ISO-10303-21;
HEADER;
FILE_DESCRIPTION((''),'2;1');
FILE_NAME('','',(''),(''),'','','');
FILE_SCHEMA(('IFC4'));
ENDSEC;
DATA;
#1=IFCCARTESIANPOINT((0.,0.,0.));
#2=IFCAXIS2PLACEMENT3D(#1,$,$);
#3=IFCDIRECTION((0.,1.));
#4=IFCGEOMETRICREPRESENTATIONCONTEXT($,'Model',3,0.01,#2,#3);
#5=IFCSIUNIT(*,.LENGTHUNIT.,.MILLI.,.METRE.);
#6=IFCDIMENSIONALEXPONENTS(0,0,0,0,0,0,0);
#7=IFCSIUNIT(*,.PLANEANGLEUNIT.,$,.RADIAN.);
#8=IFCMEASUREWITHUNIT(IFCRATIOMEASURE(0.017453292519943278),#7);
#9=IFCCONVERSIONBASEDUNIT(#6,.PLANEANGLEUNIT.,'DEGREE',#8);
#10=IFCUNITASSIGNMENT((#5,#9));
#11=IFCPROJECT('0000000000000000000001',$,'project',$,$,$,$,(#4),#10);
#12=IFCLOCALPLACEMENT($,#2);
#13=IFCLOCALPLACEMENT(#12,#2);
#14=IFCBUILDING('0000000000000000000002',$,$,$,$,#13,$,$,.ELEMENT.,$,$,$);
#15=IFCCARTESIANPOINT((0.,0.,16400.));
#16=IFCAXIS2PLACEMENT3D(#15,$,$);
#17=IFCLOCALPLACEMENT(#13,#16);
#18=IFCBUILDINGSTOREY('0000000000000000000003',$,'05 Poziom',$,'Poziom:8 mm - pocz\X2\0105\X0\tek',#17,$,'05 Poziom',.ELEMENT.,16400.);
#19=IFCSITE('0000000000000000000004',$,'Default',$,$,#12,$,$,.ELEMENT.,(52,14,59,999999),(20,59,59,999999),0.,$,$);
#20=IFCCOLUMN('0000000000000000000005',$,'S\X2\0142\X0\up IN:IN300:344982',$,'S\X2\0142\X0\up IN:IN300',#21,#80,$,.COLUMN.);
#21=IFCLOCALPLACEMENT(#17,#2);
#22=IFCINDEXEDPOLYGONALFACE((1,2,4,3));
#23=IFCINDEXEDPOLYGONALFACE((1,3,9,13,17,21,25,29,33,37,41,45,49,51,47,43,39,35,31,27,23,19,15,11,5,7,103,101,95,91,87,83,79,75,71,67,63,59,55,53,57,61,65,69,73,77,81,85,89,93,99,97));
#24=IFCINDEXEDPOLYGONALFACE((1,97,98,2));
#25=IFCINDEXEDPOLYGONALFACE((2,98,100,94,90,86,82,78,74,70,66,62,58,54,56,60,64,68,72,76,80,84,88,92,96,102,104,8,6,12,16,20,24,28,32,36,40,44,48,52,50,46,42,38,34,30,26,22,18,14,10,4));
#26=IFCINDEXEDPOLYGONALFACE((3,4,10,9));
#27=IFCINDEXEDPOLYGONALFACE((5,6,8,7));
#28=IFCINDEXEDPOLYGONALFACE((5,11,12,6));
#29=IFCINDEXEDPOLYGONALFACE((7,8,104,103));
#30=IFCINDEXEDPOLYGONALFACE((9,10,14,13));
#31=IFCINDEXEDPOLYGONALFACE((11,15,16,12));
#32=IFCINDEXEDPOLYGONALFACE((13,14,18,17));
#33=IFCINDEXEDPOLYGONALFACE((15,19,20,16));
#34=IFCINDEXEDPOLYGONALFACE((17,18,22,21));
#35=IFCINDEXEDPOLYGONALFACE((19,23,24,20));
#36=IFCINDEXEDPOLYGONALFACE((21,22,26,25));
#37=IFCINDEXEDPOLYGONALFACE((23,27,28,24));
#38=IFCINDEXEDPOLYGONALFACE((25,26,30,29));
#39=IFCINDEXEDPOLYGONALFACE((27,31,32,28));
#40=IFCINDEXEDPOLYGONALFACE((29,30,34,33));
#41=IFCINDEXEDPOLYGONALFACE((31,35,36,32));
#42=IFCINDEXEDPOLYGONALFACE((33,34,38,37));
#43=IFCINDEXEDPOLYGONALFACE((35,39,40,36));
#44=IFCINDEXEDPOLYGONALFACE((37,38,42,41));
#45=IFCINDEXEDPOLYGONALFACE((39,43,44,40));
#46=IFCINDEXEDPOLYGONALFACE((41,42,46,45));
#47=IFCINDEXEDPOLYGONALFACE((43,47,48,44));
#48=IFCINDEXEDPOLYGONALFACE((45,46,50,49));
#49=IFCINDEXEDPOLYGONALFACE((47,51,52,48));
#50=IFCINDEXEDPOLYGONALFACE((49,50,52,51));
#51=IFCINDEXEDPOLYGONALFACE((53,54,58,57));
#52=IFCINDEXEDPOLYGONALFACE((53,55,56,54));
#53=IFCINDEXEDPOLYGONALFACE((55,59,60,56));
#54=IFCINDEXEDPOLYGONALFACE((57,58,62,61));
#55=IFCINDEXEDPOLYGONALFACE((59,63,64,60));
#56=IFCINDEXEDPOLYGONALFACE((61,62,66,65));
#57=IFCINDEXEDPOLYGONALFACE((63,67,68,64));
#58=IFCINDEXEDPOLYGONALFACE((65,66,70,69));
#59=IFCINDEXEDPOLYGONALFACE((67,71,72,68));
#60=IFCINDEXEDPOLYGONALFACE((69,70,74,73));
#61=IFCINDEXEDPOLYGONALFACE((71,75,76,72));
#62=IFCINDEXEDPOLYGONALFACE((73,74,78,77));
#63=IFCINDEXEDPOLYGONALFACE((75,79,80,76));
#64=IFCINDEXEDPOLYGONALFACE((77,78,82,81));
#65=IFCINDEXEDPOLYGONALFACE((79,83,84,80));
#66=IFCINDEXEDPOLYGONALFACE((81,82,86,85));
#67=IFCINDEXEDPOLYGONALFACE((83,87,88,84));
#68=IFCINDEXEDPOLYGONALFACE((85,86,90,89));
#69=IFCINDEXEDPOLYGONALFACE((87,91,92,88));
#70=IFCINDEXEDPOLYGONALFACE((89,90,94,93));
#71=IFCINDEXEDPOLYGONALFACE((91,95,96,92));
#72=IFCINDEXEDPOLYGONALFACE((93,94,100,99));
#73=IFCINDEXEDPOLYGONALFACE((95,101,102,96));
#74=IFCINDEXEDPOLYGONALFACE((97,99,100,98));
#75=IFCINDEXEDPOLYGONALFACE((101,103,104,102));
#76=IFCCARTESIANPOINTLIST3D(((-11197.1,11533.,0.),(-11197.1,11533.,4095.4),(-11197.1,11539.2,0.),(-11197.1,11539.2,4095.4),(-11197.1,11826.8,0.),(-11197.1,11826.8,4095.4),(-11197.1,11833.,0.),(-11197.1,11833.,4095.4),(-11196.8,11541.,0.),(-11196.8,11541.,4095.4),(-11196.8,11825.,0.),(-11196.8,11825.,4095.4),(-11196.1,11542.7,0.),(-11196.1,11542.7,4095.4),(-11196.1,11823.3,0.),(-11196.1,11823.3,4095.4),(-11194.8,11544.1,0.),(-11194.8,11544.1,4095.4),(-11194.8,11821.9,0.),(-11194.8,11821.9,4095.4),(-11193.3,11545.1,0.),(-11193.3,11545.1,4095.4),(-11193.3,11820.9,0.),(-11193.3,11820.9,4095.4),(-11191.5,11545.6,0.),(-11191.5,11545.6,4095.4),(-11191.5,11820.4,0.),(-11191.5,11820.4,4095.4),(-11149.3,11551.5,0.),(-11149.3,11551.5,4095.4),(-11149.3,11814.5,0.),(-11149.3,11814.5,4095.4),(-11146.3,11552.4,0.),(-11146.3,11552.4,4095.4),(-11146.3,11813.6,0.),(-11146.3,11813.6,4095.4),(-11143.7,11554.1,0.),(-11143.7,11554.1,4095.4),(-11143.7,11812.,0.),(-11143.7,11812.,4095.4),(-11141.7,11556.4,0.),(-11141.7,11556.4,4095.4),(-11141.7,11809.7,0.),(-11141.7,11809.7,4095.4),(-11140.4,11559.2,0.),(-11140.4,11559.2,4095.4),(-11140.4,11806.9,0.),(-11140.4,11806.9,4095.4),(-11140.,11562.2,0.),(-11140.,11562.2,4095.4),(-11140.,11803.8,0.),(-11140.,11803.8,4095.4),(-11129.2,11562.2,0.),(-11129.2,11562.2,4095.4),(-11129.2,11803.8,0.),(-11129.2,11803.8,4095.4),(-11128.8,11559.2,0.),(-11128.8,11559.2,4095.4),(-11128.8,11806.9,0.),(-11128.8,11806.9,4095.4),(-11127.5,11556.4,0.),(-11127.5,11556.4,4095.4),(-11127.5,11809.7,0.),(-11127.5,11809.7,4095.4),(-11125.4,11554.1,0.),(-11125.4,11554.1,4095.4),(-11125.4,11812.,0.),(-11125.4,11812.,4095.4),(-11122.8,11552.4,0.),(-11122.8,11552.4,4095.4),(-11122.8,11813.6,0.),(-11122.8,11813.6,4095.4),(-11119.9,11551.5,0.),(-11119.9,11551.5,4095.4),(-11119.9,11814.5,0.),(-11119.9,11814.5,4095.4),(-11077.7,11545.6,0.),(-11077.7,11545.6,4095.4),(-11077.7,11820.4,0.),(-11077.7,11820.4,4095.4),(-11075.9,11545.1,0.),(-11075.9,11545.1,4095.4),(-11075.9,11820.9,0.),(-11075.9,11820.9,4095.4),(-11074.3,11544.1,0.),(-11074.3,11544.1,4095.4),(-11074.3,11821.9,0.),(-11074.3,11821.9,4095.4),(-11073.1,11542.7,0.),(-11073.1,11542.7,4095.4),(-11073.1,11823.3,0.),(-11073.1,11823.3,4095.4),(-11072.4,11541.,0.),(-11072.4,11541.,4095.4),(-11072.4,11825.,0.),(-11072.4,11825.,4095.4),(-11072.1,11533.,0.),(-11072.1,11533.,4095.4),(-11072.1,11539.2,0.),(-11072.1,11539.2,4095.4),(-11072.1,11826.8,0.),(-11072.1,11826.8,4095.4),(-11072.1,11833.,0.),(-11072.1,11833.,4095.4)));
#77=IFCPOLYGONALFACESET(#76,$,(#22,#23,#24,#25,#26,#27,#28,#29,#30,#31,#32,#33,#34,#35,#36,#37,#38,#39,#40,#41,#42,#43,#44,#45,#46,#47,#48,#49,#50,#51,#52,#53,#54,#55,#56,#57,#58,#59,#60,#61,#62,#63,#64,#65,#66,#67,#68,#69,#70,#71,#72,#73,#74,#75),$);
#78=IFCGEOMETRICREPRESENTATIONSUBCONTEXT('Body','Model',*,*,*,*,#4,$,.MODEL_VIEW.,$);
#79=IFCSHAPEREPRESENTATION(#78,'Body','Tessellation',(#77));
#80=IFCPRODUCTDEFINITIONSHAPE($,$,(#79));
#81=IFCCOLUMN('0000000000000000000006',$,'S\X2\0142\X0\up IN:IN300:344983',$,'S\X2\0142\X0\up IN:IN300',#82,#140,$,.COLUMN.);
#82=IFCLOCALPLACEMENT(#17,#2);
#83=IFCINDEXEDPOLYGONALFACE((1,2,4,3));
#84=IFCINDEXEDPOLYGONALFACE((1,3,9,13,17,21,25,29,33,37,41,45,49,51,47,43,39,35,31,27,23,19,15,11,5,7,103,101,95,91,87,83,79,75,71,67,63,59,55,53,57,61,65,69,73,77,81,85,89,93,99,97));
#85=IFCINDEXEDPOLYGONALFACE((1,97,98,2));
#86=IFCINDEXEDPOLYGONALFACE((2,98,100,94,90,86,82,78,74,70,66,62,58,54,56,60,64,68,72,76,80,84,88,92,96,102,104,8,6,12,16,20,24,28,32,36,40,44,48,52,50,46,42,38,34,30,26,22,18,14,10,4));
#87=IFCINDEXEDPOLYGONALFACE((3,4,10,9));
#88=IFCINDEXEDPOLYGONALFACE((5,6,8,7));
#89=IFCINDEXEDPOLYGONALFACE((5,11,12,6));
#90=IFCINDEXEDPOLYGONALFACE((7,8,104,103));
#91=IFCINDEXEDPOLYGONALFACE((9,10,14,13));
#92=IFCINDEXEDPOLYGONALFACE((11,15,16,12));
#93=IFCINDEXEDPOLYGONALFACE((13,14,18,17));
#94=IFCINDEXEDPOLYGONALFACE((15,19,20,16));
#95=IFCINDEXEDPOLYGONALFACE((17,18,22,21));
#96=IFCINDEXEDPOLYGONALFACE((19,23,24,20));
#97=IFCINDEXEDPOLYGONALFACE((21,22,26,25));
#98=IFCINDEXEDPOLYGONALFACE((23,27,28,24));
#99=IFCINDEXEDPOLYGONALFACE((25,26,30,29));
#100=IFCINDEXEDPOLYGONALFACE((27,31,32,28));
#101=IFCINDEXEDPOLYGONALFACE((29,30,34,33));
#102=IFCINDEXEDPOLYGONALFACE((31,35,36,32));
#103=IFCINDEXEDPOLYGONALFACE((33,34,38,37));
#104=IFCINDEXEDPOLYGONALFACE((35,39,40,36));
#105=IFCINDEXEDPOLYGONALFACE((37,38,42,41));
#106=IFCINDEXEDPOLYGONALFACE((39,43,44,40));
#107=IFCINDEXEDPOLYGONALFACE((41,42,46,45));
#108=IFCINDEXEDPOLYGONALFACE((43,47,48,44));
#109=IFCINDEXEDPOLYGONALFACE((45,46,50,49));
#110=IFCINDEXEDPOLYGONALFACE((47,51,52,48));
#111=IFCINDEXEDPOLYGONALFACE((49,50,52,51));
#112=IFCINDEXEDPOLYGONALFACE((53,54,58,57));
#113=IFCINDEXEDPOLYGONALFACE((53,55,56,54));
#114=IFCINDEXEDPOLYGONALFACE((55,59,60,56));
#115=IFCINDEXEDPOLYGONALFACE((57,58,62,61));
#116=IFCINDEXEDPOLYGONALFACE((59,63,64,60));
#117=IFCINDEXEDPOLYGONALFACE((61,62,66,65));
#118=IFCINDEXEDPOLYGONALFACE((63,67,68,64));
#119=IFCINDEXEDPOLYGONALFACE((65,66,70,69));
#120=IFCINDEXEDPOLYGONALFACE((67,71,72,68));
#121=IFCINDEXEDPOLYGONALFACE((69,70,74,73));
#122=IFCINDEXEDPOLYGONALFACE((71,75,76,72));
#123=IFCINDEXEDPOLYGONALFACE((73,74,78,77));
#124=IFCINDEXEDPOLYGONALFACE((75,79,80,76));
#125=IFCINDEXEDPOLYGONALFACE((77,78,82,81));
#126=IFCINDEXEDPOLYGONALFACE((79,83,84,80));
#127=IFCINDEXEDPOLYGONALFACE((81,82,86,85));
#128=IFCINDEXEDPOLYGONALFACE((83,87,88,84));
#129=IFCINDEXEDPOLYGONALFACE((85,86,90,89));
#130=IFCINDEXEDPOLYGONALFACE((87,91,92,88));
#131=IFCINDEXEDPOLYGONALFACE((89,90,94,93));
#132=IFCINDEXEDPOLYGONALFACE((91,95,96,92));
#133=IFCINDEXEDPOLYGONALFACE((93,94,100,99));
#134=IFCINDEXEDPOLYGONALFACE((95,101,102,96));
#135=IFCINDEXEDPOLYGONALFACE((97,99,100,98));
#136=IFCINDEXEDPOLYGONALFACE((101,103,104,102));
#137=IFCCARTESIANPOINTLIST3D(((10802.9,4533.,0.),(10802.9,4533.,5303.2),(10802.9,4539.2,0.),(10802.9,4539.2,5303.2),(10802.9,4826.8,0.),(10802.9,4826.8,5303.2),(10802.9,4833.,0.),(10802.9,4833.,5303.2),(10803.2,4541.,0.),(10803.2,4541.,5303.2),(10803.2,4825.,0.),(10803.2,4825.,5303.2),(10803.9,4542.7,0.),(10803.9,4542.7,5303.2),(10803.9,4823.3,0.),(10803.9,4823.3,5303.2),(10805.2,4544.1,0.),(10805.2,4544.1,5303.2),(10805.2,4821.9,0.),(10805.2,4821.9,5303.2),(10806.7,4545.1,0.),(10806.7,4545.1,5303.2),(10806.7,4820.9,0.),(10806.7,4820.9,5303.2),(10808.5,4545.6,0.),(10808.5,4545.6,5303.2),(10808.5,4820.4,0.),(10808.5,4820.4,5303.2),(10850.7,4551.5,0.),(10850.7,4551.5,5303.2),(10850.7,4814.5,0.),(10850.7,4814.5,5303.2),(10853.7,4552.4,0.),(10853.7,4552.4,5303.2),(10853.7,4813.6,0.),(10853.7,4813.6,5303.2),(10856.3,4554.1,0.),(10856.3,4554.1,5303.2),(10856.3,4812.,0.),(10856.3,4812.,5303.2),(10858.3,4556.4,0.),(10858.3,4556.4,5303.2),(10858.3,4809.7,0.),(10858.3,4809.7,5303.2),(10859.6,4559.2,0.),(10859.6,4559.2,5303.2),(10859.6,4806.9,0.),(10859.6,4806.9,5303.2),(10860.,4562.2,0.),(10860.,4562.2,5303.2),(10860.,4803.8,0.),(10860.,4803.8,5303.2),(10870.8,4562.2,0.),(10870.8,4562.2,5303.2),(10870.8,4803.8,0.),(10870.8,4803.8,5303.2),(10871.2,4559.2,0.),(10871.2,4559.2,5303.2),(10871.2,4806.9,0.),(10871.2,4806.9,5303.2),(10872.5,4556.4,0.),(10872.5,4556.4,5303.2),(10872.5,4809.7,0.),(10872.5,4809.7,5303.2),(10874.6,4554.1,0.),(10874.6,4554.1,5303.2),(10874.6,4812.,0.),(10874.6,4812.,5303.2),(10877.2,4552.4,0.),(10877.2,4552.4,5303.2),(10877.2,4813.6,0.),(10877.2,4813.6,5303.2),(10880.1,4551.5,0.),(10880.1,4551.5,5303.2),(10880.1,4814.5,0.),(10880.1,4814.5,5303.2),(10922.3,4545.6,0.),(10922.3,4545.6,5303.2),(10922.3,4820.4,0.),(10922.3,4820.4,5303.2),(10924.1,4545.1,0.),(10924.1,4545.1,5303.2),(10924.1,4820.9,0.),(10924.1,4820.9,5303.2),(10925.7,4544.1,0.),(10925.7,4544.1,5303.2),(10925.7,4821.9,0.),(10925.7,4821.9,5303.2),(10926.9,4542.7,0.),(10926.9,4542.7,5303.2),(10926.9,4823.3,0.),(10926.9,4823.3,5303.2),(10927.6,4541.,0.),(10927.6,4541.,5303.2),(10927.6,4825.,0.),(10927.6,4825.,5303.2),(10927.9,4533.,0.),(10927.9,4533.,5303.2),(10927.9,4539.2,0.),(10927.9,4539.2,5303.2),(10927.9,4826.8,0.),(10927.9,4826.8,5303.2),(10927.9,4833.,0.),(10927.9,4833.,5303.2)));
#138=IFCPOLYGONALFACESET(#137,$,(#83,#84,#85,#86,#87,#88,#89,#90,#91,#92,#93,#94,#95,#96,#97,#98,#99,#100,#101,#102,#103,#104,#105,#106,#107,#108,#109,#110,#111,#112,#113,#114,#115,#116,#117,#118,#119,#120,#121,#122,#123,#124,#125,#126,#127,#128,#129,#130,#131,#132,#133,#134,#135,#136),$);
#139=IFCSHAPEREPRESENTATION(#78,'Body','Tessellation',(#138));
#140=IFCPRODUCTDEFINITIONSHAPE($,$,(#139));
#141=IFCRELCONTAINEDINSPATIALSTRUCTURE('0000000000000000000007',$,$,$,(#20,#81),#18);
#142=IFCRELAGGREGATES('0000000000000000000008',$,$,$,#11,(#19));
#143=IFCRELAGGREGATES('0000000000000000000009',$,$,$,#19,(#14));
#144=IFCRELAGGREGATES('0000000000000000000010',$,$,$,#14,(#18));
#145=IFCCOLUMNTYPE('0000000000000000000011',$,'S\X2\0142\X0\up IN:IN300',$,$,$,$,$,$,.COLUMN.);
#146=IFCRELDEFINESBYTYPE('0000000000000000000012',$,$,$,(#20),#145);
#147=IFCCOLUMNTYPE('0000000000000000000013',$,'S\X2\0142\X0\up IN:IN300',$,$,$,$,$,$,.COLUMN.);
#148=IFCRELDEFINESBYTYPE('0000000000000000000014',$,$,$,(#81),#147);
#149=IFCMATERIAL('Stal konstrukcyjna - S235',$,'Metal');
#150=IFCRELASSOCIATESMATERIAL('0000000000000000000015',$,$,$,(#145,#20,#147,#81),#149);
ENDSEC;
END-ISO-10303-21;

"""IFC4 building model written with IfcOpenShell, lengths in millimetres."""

from ifc_helpers import new_model, entity, si_unit, converted_unit, direction, frame, origin, place, context, subcontext, project, spatial, line, arc, indexed_curve, outline, extrude, source, transform, mapped, material, type_object, type_shapes, element, save


model = new_model("IFC4")

# Units and contexts
model_context = context("Model", 3, precision=0.01, world=origin(), true_north=direction((0.0, 1.0)))
body_context = subcontext(model_context, "Body", "Model", "MODEL_VIEW")
ifc_project = project(units=[si_unit("LENGTHUNIT", "METRE", prefix="MILLI"), converted_unit("PLANEANGLEUNIT", "DEGREE", entity("IfcRatioMeasure", 0.017453292519943278), si_unit("PLANEANGLEUNIT", "RADIAN"), dimensions=[0, 0, 0, 0, 0, 0, 0])], contexts=[model_context])

# Site, building, storey
site_placement = place(None, origin())
site = spatial("IfcSite", under=ifc_project, at=site_placement, Name="Default", CompositionType="ELEMENT", RefLatitude=(52, 14, 59, 999999), RefLongitude=(20, 59, 59, 999999), RefElevation=0.0)
building_placement = place(site_placement, origin())
building = spatial("IfcBuilding", under=site, at=building_placement, CompositionType="ELEMENT")
storey_placement = place(building_placement, frame((0.0, 0.0, 16400.0)))
storey = spatial("IfcBuildingStorey", under=building, at=storey_placement, Name="05 Poziom", ObjectType="Poziom:8 mm - początek", LongName="05 Poziom", CompositionType="ELEMENT", Elevation=16400.0)

# Columns
ifc_material = material(Name="Stal konstrukcyjna - S235", Category="Metal")
column_type_1 = type_object("IfcColumnType", Name="Słup IN:IN300", PredefinedType="COLUMN", material=ifc_material)
shared_shape_1 = source(origin(), body_context, "Body", "SweptSolid", [
    extrude(outline(indexed_curve([(143.8, -62.5), (150.0, -62.5), (150.0, 62.5), (143.8, 62.5), (139.6, 60.9), (137.4, 56.9), (131.5, 14.7), (127.9, 8.1), (120.8, 5.4), (-120.8, 5.4), (-127.9, 8.1), (-131.5, 14.7), (-137.4, 56.9), (-139.6, 60.9), (-143.8, 62.5), (-150.0, 62.5), (-150.0, -62.5), (-143.8, -62.5), (-139.6, -60.9), (-137.4, -56.9), (-131.5, -14.7), (-127.9, -8.1), (-120.8, -5.4), (120.8, -5.4), (127.9, -8.1), (131.5, -14.7), (137.4, -56.9), (139.6, -60.9)], segments=[line(1, 2, 3, 4), arc(4, 5, 6), line(6, 7), arc(7, 8, 9), line(9, 10), arc(10, 11, 12), line(12, 13), arc(13, 14, 15), line(15, 16, 17, 18), arc(18, 19, 20), line(20, 21), arc(21, 22, 23), line(23, 24), arc(24, 25, 26), line(26, 27), arc(27, 28, 1)], self_intersect=False)), frame((-11134.6, 11683.0, 16400.0), z_axis=(0.0, 0.0, 1.0), x_axis=(0.0, -1.0, 0.0)), (0.0, 0.0, 1.0), 4095.4),
])
type_shapes(column_type_1, [shared_shape_1])
column_1_placement = place(storey_placement, frame((0.0, 0.0, -16400.0)))
element("IfcColumn", 1, at=column_1_placement, inside=storey, type_object=column_type_1, material=ifc_material, Name="Słup IN:IN300:344982", ObjectType="Słup IN:IN300", PredefinedType="COLUMN", context=body_context, shape_type="MappedRepresentation", body=[
    mapped(shared_shape_1, transform((0.0, 0.0, 0.0), scale=1.0)),
])
column_type_2 = type_object("IfcColumnType", Name="Słup IN:IN300", PredefinedType="COLUMN", material=ifc_material)
shared_shape_2 = source(origin(), body_context, "Body", "SweptSolid", [
    extrude(outline(indexed_curve([(143.8, -62.5), (150.0, -62.5), (150.0, 62.5), (143.8, 62.5), (139.6, 60.9), (137.4, 56.9), (131.5, 14.7), (127.9, 8.1), (120.8, 5.4), (-120.8, 5.4), (-127.9, 8.1), (-131.5, 14.7), (-137.4, 56.9), (-139.6, 60.9), (-143.8, 62.5), (-150.0, 62.5), (-150.0, -62.5), (-143.8, -62.5), (-139.6, -60.9), (-137.4, -56.9), (-131.5, -14.7), (-127.9, -8.1), (-120.8, -5.4), (120.8, -5.4), (127.9, -8.1), (131.5, -14.7), (137.4, -56.9), (139.6, -60.9)], segments=[line(1, 2, 3, 4), arc(4, 5, 6), line(6, 7), arc(7, 8, 9), line(9, 10), arc(10, 11, 12), line(12, 13), arc(13, 14, 15), line(15, 16, 17, 18), arc(18, 19, 20), line(20, 21), arc(21, 22, 23), line(23, 24), arc(24, 25, 26), line(26, 27), arc(27, 28, 1)], self_intersect=False)), frame((10865.4, 4683.0, 16400.0), z_axis=(0.0, 0.0, 1.0), x_axis=(0.0, -1.0, 0.0)), (0.0, 0.0, 1.0), 5303.2),
])
type_shapes(column_type_2, [shared_shape_2])
column_2_placement = place(storey_placement, frame((0.0, 0.0, -16400.0)))
element("IfcColumn", 2, at=column_2_placement, inside=storey, type_object=column_type_2, material=ifc_material, Name="Słup IN:IN300:344983", ObjectType="Słup IN:IN300", PredefinedType="COLUMN", context=body_context, shape_type="MappedRepresentation", body=[
    mapped(shared_shape_2, transform((0.0, 0.0, 0.0), scale=1.0)),
])

save(model, "model.ifc")
